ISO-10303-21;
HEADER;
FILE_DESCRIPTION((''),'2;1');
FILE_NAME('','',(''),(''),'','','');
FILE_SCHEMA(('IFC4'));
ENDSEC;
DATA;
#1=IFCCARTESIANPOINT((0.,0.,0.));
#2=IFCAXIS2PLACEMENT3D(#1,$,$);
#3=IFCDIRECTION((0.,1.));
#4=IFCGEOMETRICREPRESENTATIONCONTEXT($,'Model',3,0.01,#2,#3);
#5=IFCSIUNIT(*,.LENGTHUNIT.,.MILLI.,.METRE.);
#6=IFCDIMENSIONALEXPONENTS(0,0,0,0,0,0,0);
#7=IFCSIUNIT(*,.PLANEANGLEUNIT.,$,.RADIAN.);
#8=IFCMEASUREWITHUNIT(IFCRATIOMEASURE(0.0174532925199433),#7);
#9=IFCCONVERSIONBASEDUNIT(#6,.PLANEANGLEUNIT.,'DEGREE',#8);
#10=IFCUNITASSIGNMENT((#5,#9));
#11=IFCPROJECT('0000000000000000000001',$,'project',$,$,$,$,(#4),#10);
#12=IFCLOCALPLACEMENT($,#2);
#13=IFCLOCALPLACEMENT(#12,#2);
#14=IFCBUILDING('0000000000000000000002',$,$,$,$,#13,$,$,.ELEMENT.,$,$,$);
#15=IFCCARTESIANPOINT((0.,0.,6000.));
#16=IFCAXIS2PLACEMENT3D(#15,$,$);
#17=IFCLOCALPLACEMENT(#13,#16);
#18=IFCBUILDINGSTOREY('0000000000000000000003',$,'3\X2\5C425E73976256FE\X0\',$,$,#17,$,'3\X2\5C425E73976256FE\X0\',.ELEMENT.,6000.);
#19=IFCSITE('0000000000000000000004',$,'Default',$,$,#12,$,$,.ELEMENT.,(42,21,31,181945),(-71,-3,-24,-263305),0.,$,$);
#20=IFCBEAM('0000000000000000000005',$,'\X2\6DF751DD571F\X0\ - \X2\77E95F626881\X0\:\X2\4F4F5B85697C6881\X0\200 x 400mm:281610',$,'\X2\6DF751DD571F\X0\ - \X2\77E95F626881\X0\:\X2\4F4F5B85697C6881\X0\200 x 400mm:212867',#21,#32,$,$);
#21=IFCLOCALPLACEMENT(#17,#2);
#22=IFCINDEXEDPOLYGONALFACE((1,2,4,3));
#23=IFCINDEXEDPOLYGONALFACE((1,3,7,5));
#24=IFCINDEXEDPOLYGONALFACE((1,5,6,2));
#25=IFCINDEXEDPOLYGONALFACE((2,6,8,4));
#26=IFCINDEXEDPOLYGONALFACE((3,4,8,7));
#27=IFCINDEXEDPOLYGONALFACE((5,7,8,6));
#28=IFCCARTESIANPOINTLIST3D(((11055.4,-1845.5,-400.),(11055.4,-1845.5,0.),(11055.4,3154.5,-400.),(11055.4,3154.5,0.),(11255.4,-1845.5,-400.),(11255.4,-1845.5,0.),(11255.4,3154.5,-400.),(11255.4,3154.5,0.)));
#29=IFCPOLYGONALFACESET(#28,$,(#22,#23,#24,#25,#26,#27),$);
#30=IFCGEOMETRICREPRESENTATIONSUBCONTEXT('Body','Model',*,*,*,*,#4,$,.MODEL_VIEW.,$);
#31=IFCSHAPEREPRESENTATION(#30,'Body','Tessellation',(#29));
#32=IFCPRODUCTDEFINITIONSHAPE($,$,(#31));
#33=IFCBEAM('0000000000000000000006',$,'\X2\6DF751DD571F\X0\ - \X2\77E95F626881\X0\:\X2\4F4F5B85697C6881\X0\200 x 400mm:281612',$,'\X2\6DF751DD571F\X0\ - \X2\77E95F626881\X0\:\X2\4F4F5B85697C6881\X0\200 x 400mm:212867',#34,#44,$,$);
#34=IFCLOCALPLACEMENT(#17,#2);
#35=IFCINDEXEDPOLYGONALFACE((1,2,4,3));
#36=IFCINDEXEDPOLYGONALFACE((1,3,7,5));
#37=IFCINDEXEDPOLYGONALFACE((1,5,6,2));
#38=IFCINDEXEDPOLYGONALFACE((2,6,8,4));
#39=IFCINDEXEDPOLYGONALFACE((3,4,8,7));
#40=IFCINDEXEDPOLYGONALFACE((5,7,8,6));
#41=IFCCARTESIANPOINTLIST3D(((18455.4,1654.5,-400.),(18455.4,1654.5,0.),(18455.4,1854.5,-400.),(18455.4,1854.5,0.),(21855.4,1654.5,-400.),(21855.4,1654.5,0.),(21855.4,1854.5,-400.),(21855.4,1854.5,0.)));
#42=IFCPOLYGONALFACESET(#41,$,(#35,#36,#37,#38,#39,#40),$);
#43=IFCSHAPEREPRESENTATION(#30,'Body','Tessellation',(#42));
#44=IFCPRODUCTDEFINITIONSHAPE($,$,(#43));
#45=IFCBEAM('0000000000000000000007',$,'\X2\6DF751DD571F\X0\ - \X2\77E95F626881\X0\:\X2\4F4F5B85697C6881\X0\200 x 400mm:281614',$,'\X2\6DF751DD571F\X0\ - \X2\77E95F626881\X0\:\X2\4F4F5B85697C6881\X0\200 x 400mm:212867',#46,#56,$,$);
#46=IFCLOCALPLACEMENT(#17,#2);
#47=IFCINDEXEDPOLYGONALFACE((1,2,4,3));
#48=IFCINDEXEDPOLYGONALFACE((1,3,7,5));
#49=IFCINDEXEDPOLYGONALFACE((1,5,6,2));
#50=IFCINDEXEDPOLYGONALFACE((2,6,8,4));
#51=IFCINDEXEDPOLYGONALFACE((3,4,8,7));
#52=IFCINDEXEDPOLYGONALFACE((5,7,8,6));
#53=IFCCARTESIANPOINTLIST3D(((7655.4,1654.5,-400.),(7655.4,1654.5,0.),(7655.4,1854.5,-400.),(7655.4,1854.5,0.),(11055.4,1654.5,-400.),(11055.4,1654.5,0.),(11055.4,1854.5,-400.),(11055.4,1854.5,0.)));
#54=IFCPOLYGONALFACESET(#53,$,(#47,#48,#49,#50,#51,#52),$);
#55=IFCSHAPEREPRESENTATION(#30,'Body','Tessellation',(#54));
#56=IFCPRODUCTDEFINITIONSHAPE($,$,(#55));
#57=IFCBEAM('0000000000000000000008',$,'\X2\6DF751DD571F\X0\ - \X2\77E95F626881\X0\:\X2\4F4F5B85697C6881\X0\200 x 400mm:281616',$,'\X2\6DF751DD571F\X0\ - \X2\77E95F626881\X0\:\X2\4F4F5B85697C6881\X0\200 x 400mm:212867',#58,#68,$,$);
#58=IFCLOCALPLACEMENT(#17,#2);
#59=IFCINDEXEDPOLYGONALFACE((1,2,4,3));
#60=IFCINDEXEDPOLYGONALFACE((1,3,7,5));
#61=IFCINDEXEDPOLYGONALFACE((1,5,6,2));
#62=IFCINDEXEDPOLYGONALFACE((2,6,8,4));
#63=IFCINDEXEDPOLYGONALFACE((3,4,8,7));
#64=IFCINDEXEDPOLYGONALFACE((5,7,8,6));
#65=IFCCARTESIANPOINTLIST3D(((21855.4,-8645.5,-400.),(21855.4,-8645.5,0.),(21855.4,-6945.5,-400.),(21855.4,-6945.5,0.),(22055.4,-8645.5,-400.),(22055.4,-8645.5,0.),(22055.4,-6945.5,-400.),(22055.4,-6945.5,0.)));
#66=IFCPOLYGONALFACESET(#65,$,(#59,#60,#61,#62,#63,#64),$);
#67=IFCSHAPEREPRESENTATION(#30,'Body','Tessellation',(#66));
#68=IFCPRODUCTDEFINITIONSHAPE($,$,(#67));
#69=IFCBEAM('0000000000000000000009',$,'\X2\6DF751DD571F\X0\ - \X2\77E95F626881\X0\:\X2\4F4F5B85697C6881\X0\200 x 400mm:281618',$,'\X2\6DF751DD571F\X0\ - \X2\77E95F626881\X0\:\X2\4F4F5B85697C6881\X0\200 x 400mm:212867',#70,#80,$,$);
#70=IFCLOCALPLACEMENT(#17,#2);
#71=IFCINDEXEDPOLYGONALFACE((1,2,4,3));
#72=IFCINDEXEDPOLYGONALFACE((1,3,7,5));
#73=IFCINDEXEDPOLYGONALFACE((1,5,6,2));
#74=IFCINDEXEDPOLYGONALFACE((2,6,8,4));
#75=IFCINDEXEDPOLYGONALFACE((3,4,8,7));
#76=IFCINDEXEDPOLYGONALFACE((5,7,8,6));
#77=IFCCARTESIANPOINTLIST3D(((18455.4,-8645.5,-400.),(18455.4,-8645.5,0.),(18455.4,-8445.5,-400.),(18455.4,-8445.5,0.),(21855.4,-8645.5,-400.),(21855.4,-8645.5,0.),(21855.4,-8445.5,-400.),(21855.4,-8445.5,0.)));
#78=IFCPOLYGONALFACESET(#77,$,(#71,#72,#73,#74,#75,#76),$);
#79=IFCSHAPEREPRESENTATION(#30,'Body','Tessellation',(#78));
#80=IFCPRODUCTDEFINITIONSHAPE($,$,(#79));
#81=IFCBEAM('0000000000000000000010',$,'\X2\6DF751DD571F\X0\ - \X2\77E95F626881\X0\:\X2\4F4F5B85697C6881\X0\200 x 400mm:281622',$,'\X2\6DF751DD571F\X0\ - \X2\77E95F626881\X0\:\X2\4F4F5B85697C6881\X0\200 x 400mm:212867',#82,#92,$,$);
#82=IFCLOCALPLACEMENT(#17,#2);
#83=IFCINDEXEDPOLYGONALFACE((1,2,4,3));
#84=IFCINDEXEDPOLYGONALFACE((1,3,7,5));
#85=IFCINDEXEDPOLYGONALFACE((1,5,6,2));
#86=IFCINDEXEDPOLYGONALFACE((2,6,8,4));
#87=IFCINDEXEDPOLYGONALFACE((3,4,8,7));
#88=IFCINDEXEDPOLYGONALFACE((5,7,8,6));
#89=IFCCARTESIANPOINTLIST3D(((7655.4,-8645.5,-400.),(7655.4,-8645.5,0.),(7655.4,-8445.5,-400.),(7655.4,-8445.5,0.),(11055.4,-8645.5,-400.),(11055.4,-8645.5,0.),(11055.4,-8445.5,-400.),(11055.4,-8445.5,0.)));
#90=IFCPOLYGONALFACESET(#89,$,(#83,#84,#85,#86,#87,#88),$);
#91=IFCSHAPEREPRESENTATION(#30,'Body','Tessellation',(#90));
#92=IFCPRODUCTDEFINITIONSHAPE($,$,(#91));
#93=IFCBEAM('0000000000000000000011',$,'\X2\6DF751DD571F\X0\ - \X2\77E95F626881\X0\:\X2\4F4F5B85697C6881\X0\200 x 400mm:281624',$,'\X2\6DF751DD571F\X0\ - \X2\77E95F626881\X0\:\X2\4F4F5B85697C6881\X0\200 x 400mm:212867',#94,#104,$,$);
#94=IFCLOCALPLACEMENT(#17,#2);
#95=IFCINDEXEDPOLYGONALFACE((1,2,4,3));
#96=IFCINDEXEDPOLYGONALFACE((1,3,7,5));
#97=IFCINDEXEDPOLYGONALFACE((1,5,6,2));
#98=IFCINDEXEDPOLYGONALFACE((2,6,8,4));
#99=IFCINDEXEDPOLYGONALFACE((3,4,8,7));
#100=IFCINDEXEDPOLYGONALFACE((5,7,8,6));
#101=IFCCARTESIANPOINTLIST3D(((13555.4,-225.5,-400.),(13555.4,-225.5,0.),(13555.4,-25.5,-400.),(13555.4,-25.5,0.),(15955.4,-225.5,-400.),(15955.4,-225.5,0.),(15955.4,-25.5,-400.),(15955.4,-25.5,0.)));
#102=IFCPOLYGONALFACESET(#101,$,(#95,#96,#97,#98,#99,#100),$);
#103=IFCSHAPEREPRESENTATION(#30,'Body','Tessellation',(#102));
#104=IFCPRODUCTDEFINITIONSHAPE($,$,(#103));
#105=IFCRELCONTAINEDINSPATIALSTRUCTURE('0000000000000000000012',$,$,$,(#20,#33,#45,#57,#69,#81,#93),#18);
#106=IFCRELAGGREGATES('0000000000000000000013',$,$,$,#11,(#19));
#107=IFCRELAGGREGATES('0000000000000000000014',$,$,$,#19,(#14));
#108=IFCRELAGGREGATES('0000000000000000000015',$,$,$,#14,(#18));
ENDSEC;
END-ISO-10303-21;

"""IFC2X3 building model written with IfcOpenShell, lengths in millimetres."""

from ifc_helpers import new_model, entity, si_unit, converted_unit, direction, frame, frame_2d, origin, place, context, subcontext, project, spatial, rectangle, extrude, element, save


model = new_model("IFC2X3")

# Units and contexts
model_context = context("Model", 3, precision=0.01, world=origin(), true_north=direction((0.0, 1.0)))
body_context = subcontext(model_context, "Body", "Model", "MODEL_VIEW")
ifc_project = project(units=[si_unit("LENGTHUNIT", "METRE", prefix="MILLI"), converted_unit("PLANEANGLEUNIT", "DEGREE", entity("IfcRatioMeasure", 0.0174532925199433), si_unit("PLANEANGLEUNIT", "RADIAN"), dimensions=[0, 0, 0, 0, 0, 0, 0])], contexts=[model_context])

# Site, building, storey
site_placement = place(None, origin())
site = spatial("IfcSite", under=ifc_project, at=site_placement, Name="Default", CompositionType="ELEMENT", RefLatitude=(42, 21, 31, 181945), RefLongitude=(-71, -3, -24, -263305), RefElevation=0.0)
building_placement = place(site_placement, origin())
building = spatial("IfcBuilding", under=site, at=building_placement, CompositionType="ELEMENT")
storey_placement = place(building_placement, frame((0.0, 0.0, 6000.0)))
storey = spatial("IfcBuildingStorey", under=building, at=storey_placement, Name="3层平面图", LongName="3层平面图", CompositionType="ELEMENT", Elevation=6000.0)

# Beams
beam_1_placement = place(storey_placement, frame((11155.4, 3254.5, 0.0), z_axis=(0.0, 0.0, 1.0), x_axis=(0.0, -1.0, 0.0)))
element("IfcBeam", 1, at=beam_1_placement, inside=storey, Name="混凝土 - 矩形梁:住宅楼梁200 x 400mm:281610", ObjectType="混凝土 - 矩形梁:住宅楼梁200 x 400mm:212867", context=body_context, shape_type="SweptSolid", body=[
    extrude(rectangle(XDim=400.0, YDim=200.0, at=frame_2d((0.0, 0.0), x_axis=(1.0, 0.0))), frame((100.0, 0.0, -200.0), z_axis=(1.0, 0.0, 0.0), x_axis=(0.0, 0.0, -1.0)), (0.0, 0.0, 1.0), 5000.0),
])
beam_2_placement = place(storey_placement, frame((21955.4, 1754.5, 0.0), z_axis=(0.0, 0.0, 1.0), x_axis=(-1.0, 0.0, 0.0)))
element("IfcBeam", 2, at=beam_2_placement, inside=storey, Name="混凝土 - 矩形梁:住宅楼梁200 x 400mm:281612", ObjectType="混凝土 - 矩形梁:住宅楼梁200 x 400mm:212867", context=body_context, shape_type="SweptSolid", body=[
    extrude(rectangle(XDim=400.0, YDim=200.0, at=frame_2d((0.0, 0.0), x_axis=(1.0, 0.0))), frame((100.0, 0.0, -200.0), z_axis=(1.0, 0.0, 0.0), x_axis=(0.0, 0.0, -1.0)), (0.0, 0.0, 1.0), 3400.0),
])
beam_3_placement = place(storey_placement, frame((7555.4, 1754.5, 0.0)))
element("IfcBeam", 3, at=beam_3_placement, inside=storey, Name="混凝土 - 矩形梁:住宅楼梁200 x 400mm:281614", ObjectType="混凝土 - 矩形梁:住宅楼梁200 x 400mm:212867", context=body_context, shape_type="SweptSolid", body=[
    extrude(rectangle(XDim=400.0, YDim=200.0, at=frame_2d((0.0, 0.0), x_axis=(1.0, 0.0))), frame((100.0, 0.0, -200.0), z_axis=(1.0, 0.0, 0.0), x_axis=(0.0, 0.0, -1.0)), (0.0, 0.0, 1.0), 3400.0),
])
beam_4_placement = place(storey_placement, frame((21955.4, -6745.5, 0.0), z_axis=(0.0, 0.0, 1.0), x_axis=(0.0, -1.0, 0.0)))
element("IfcBeam", 4, at=beam_4_placement, inside=storey, Name="混凝土 - 矩形梁:住宅楼梁200 x 400mm:281616", ObjectType="混凝土 - 矩形梁:住宅楼梁200 x 400mm:212867", context=body_context, shape_type="SweptSolid", body=[
    extrude(rectangle(XDim=400.0, YDim=200.0, at=frame_2d((0.0, 0.0), x_axis=(1.0, 0.0))), frame((200.0, 0.0, -200.0), z_axis=(1.0, 0.0, 0.0), x_axis=(0.0, 0.0, -1.0)), (0.0, 0.0, 1.0), 1700.0),
])
beam_5_placement = place(storey_placement, frame((21955.4, -8545.5, 0.0), z_axis=(0.0, 0.0, 1.0), x_axis=(-1.0, 0.0, 0.0)))
element("IfcBeam", 5, at=beam_5_placement, inside=storey, Name="混凝土 - 矩形梁:住宅楼梁200 x 400mm:281618", ObjectType="混凝土 - 矩形梁:住宅楼梁200 x 400mm:212867", context=body_context, shape_type="SweptSolid", body=[
    extrude(rectangle(XDim=400.0, YDim=200.0, at=frame_2d((0.0, 0.0), x_axis=(1.0, 0.0))), frame((100.0, 0.0, -200.0), z_axis=(1.0, 0.0, 0.0), x_axis=(0.0, 0.0, -1.0)), (0.0, 0.0, 1.0), 3400.0),
])
beam_6_placement = place(storey_placement, frame((7555.4, -8545.5, 0.0)))
element("IfcBeam", 6, at=beam_6_placement, inside=storey, Name="混凝土 - 矩形梁:住宅楼梁200 x 400mm:281622", ObjectType="混凝土 - 矩形梁:住宅楼梁200 x 400mm:212867", context=body_context, shape_type="SweptSolid", body=[
    extrude(rectangle(XDim=400.0, YDim=200.0, at=frame_2d((0.0, 0.0), x_axis=(1.0, 0.0))), frame((100.0, 0.0, -200.0), z_axis=(1.0, 0.0, 0.0), x_axis=(0.0, 0.0, -1.0)), (0.0, 0.0, 1.0), 3400.0),
])
beam_7_placement = place(storey_placement, frame((16055.4, -125.5, 0.0), z_axis=(0.0, 0.0, 1.0), x_axis=(-1.0, 0.0, 0.0)))
element("IfcBeam", 7, at=beam_7_placement, inside=storey, Name="混凝土 - 矩形梁:住宅楼梁200 x 400mm:281624", ObjectType="混凝土 - 矩形梁:住宅楼梁200 x 400mm:212867", context=body_context, shape_type="SweptSolid", body=[
    extrude(rectangle(XDim=400.0, YDim=200.0, at=frame_2d((0.0, 0.0), x_axis=(1.0, 0.0))), frame((100.0, 0.0, -200.0), z_axis=(1.0, 0.0, 0.0), x_axis=(0.0, 0.0, -1.0)), (0.0, 0.0, 1.0), 2400.0),
])

save(model, "model.ifc")
